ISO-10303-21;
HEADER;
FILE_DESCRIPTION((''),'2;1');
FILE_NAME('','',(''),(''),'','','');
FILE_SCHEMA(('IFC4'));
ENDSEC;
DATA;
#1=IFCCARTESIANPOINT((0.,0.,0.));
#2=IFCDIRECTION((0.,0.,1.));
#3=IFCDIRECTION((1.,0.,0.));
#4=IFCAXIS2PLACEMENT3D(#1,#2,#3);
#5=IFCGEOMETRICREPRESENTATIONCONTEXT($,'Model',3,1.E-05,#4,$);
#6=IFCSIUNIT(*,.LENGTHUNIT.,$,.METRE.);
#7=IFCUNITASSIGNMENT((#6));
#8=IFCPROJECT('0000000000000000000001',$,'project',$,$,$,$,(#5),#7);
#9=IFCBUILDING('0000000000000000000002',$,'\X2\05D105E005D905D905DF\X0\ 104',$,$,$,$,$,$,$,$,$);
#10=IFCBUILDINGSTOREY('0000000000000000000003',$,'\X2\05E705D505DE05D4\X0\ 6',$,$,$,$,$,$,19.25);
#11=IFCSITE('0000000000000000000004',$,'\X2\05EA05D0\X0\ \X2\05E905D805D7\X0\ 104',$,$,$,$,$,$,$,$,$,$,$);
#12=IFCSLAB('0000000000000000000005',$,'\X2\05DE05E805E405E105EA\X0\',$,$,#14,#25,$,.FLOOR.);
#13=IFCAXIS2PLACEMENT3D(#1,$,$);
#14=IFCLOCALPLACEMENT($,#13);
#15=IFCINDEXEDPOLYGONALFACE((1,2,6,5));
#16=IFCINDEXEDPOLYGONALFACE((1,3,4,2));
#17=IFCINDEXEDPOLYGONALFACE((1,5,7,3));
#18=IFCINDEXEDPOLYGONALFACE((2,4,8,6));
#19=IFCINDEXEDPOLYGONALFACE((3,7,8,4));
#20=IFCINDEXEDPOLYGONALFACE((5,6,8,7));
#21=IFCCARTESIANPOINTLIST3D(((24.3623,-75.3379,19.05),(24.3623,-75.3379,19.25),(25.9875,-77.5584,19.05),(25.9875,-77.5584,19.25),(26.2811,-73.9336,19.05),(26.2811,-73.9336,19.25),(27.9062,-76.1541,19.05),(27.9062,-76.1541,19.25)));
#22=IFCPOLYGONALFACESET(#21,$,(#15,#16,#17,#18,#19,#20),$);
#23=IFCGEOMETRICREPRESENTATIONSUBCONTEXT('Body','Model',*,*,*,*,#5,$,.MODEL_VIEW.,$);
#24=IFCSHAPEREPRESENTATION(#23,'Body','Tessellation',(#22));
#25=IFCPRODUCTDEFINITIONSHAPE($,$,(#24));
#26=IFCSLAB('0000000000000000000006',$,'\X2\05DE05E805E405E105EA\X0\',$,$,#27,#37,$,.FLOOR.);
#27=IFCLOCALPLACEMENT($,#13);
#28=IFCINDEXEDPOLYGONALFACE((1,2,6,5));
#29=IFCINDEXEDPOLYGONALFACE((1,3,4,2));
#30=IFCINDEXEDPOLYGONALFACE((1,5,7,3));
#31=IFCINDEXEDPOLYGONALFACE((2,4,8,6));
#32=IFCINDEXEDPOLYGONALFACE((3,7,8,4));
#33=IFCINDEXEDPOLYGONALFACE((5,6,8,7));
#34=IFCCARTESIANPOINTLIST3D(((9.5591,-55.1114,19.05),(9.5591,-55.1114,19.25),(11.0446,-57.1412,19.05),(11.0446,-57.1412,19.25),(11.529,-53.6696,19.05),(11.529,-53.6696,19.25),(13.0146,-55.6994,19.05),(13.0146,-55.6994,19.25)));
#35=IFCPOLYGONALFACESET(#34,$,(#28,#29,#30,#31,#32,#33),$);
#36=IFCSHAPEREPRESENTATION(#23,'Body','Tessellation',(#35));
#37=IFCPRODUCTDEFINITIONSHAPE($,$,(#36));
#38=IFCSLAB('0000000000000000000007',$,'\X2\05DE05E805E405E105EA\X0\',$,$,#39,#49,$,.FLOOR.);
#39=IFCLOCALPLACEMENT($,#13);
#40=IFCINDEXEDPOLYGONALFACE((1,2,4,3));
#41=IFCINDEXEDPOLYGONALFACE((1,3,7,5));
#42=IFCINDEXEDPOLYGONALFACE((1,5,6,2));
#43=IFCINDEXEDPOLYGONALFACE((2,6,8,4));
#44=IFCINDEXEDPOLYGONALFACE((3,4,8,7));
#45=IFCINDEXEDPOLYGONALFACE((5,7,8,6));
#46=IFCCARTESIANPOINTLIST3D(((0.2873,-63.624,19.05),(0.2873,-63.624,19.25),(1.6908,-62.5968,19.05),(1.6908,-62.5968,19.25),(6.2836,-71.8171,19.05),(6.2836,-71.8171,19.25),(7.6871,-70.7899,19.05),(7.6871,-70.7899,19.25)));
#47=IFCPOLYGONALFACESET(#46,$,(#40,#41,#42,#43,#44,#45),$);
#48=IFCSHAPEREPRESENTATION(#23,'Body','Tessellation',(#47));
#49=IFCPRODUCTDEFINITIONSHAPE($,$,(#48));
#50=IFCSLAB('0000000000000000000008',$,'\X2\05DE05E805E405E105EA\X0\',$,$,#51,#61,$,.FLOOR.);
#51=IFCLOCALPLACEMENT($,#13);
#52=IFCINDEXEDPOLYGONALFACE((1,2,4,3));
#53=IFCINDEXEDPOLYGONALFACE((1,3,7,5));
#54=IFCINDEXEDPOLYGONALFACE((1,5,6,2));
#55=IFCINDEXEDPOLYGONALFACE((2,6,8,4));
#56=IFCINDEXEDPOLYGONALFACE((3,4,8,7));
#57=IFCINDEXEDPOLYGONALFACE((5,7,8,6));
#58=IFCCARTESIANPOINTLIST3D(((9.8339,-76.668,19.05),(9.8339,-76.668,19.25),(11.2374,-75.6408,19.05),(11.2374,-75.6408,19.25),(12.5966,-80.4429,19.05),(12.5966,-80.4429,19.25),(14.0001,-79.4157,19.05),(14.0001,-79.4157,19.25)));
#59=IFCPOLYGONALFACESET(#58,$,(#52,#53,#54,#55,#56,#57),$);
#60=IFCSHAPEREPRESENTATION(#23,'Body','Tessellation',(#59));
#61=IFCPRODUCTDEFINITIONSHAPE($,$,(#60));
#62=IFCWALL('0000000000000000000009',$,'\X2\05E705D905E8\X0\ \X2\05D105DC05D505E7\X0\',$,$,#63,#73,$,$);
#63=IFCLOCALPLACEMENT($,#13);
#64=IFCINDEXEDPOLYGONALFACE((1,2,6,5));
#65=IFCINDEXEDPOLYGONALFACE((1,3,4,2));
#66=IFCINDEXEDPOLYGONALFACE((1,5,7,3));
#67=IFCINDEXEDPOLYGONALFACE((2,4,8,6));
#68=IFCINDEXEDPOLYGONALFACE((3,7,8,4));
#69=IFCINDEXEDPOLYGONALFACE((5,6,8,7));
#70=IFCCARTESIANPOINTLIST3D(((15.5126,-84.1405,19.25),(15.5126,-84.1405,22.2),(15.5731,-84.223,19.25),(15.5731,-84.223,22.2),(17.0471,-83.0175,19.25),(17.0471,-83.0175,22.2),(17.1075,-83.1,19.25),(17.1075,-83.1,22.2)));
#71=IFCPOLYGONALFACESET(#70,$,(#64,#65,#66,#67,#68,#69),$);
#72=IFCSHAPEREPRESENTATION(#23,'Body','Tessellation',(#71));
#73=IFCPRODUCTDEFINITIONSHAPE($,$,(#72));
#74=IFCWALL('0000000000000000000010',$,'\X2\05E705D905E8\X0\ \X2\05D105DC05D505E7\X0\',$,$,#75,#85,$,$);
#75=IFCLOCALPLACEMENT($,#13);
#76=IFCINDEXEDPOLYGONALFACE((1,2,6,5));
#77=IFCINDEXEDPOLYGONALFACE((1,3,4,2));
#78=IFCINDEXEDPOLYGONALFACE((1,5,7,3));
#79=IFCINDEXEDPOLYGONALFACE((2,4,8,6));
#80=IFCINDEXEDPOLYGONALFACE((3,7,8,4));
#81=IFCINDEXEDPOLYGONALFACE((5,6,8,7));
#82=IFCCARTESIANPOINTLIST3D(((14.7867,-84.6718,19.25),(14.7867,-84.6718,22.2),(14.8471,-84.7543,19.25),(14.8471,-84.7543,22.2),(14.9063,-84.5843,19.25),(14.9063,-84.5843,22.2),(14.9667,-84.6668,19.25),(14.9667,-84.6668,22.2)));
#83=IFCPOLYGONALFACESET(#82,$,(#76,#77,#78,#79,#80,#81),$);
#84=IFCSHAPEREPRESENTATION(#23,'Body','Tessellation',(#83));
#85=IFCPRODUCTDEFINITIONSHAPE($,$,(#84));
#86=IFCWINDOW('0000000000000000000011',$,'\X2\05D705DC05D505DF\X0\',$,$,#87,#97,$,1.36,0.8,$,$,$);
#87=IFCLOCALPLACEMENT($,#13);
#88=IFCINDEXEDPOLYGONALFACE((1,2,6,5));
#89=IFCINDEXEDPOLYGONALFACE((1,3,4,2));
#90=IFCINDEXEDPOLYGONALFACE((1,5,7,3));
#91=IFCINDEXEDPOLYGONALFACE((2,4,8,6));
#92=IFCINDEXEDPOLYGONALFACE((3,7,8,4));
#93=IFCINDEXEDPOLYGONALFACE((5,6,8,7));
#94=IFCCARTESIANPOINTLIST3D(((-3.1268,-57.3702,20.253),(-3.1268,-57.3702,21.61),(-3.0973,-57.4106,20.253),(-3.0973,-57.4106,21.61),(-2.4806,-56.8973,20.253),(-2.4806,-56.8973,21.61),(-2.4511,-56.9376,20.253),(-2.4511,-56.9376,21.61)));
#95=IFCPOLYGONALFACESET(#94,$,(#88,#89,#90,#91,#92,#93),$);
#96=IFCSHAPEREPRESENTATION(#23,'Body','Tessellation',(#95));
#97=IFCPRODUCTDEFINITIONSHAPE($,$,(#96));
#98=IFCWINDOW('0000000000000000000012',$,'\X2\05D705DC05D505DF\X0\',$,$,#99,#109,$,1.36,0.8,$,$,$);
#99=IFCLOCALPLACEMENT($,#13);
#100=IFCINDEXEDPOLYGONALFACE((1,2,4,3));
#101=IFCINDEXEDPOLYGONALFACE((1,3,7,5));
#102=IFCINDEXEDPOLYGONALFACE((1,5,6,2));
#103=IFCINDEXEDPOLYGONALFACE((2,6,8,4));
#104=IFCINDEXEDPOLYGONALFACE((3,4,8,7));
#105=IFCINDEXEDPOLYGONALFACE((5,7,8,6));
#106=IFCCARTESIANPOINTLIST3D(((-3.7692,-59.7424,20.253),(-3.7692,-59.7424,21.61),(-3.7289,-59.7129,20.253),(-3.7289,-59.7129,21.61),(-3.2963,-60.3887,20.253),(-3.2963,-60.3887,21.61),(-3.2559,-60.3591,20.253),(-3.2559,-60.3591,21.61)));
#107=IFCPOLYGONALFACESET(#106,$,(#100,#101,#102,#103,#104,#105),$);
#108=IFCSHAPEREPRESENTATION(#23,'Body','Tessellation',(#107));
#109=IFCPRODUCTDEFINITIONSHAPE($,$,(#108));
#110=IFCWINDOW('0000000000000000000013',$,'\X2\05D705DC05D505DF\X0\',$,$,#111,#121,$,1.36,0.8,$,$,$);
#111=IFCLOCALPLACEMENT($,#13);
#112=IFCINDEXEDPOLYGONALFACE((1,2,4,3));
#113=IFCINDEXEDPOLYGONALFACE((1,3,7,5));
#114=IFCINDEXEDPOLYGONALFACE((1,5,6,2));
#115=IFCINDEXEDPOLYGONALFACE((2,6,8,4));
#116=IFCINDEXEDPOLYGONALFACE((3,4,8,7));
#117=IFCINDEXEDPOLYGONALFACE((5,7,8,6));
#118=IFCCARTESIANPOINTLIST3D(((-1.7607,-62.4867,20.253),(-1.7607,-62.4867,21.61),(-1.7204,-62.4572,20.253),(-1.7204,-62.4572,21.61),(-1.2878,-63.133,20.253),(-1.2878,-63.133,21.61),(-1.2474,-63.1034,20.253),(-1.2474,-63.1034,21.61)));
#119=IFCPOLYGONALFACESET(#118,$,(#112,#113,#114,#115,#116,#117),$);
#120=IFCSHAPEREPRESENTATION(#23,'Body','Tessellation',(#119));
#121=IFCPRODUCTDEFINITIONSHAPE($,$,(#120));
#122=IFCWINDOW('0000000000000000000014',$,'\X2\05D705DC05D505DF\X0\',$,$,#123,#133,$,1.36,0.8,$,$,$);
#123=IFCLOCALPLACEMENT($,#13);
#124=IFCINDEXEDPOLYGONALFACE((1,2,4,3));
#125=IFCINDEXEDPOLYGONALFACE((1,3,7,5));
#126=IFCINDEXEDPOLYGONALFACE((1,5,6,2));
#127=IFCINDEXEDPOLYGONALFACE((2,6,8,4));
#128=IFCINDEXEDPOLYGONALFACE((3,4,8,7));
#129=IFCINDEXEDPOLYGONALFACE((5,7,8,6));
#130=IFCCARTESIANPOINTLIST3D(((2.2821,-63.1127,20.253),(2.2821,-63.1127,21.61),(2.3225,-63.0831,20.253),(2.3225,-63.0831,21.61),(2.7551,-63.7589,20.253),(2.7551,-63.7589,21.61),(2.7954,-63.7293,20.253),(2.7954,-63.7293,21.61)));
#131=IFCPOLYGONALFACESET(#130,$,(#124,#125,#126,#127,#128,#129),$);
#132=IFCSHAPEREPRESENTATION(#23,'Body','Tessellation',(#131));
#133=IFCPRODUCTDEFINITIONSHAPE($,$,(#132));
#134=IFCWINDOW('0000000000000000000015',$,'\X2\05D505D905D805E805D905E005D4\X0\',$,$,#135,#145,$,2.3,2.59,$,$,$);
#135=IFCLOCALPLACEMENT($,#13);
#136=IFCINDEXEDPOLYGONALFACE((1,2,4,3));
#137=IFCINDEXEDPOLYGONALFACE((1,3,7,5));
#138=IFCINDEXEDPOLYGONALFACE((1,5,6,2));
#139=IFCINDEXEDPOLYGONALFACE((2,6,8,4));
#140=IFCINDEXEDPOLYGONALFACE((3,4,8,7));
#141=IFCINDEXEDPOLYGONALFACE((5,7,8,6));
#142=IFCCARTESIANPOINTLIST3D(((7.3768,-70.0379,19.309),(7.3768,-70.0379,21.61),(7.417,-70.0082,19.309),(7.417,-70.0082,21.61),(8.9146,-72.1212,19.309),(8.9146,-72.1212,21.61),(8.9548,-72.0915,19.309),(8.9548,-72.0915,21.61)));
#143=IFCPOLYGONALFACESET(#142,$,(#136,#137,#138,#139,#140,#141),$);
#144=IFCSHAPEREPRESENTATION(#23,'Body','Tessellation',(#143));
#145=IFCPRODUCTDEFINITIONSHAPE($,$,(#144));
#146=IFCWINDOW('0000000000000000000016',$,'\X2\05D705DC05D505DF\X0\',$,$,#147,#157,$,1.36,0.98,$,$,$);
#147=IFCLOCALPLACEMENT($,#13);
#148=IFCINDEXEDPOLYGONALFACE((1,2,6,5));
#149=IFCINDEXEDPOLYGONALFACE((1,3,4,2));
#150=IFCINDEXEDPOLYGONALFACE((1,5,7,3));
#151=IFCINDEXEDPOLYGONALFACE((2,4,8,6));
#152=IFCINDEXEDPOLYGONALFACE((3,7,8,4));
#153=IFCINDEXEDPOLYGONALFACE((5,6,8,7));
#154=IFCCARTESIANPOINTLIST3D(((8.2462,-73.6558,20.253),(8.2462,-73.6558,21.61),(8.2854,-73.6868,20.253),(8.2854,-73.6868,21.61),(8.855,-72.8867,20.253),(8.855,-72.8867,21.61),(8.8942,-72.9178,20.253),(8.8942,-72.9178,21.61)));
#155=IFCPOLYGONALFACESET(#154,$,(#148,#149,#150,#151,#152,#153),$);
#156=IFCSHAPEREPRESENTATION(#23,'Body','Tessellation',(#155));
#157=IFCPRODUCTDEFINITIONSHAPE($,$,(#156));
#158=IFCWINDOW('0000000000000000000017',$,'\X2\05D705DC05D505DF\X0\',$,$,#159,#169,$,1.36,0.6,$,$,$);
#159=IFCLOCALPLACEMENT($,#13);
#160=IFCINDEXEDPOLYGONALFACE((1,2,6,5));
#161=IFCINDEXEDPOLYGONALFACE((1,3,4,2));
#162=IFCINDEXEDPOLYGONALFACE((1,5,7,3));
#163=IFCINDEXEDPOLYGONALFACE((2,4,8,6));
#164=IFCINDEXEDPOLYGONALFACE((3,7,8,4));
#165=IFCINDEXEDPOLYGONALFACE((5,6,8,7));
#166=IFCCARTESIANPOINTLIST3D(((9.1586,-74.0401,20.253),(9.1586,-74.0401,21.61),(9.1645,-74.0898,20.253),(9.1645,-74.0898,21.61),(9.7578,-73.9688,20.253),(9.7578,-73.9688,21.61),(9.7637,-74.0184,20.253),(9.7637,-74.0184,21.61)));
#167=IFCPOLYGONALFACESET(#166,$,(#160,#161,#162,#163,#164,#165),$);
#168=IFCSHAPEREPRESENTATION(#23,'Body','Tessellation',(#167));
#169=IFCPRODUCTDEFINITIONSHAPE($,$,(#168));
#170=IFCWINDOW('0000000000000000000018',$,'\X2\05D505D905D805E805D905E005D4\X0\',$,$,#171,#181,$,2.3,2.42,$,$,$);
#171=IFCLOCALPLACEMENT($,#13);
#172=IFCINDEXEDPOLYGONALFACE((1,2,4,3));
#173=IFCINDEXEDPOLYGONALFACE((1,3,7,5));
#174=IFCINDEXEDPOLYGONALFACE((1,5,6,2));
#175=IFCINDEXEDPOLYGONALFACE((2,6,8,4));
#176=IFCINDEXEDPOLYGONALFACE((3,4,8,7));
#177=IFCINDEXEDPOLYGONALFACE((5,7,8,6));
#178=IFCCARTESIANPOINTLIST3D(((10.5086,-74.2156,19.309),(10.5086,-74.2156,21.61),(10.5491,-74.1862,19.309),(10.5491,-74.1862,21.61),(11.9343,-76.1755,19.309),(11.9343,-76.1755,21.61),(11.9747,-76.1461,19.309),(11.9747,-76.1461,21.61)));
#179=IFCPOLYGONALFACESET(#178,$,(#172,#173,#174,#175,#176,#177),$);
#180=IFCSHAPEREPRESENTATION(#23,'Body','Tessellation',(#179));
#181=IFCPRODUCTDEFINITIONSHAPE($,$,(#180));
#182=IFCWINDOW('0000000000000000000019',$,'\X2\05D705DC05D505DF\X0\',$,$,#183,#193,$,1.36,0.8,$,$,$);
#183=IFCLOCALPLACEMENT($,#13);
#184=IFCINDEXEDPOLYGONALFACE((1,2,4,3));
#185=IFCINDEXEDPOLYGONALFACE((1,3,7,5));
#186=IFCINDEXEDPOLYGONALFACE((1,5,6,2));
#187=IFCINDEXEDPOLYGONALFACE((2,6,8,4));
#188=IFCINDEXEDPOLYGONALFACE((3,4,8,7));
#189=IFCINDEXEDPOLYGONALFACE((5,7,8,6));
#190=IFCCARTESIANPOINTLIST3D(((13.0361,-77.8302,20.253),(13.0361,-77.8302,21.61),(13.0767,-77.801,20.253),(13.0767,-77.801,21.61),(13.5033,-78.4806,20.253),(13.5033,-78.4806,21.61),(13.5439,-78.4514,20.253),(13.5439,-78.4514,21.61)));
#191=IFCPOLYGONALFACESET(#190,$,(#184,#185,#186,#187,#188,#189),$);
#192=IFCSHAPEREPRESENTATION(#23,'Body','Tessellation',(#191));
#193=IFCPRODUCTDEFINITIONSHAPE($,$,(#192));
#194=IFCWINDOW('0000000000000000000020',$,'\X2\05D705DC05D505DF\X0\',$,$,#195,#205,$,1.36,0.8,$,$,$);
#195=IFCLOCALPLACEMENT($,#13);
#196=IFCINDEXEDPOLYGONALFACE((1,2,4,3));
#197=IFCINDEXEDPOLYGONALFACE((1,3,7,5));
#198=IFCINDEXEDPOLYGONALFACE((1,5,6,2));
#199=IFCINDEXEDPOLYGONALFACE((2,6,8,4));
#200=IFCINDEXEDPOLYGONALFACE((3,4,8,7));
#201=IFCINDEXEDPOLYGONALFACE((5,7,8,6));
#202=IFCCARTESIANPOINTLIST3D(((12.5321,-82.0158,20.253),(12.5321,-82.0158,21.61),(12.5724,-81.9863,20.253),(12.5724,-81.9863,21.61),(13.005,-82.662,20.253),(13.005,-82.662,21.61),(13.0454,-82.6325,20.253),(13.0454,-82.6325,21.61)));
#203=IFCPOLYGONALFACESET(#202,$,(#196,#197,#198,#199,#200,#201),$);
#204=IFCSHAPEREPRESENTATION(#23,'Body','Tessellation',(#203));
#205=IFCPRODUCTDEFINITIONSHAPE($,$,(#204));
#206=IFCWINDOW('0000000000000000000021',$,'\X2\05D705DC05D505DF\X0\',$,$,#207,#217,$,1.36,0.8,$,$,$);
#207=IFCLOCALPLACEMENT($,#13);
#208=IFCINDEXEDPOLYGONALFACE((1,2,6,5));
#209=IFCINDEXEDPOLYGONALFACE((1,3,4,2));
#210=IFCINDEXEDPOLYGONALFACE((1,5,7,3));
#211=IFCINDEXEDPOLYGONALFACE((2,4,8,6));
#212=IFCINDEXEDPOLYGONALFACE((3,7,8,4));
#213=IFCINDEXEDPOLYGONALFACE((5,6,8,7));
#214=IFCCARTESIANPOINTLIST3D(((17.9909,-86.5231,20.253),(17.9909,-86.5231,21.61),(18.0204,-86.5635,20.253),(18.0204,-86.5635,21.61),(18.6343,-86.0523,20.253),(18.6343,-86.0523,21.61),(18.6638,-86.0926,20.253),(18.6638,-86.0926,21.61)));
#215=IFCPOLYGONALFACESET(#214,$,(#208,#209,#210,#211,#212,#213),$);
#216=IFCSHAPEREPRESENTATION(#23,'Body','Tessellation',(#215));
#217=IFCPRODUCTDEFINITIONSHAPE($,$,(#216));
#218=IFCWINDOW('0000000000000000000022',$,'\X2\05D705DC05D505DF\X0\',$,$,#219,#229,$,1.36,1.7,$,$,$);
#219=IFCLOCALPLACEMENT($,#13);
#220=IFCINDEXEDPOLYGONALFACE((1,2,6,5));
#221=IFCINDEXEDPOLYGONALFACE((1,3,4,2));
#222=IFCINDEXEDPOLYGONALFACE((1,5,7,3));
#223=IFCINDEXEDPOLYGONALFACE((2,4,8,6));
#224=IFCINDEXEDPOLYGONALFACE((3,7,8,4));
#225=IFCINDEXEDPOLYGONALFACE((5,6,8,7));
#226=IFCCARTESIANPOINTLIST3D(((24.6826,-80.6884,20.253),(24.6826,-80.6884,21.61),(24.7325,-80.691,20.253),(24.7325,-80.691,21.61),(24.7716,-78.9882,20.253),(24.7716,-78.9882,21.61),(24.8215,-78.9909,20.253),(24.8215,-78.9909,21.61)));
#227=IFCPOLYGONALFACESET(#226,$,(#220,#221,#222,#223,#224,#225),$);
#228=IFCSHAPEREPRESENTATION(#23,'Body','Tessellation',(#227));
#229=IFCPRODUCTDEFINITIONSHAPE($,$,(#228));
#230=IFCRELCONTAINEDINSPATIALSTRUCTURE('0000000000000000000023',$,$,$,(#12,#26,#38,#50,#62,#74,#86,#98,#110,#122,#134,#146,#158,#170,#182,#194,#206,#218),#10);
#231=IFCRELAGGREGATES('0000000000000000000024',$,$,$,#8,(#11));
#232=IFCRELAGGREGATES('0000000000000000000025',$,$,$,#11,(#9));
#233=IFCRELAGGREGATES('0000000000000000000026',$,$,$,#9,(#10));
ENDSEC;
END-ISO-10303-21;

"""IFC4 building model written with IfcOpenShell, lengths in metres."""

from ifc_helpers import new_model, si_unit, frame, origin_with_axes, context, subcontext, project, spatial, polyline, outline, extrude, element, save


model = new_model("IFC4")

# Units and contexts
model_context = context("Model", 3, precision=1e-05, world=origin_with_axes())
body_context = subcontext(model_context, "Body", "Model", "MODEL_VIEW")
ifc_project = project(units=[si_unit("LENGTHUNIT", "METRE")], contexts=[model_context])

# Site, building, storey
site = spatial("IfcSite", under=ifc_project, Name="תא שטח 104")
building = spatial("IfcBuilding", under=site, Name="בניין 104")
storey = spatial("IfcBuildingStorey", under=building, Name="קומה 6", Elevation=19.25)

# Slabs
element("IfcSlab", 1, inside=storey, Name="מרפסת", PredefinedType="FLOOR", context=body_context, shape_type="SweptSolid", body=[
    extrude(outline(polyline([(26.2811, -73.9336), (27.9062, -76.1541), (25.9875, -77.5584), (24.3623, -75.3379), (26.2811, -73.9336)])), frame((0.0, 0.0, 19.05)), (0.0, 0.0, 1.0), 0.2),
])
element("IfcSlab", 2, inside=storey, Name="מרפסת", PredefinedType="FLOOR", context=body_context, shape_type="SweptSolid", body=[
    extrude(outline(polyline([(11.529, -53.6696), (13.0146, -55.6994), (11.0446, -57.1412), (9.5591, -55.1114), (11.529, -53.6696)])), frame((0.0, 0.0, 19.05)), (0.0, 0.0, 1.0), 0.2),
])
element("IfcSlab", 3, inside=storey, Name="מרפסת", PredefinedType="FLOOR", context=body_context, shape_type="SweptSolid", body=[
    extrude(outline(polyline([(1.6908, -62.5968), (7.6871, -70.7899), (6.2836, -71.8171), (0.2873, -63.624), (1.6908, -62.5968)])), frame((0.0, 0.0, 19.05)), (0.0, 0.0, 1.0), 0.2),
])
element("IfcSlab", 4, inside=storey, Name="מרפסת", PredefinedType="FLOOR", context=body_context, shape_type="SweptSolid", body=[
    extrude(outline(polyline([(11.2374, -75.6408), (14.0001, -79.4157), (12.5966, -80.4429), (9.8339, -76.668), (11.2374, -75.6408)])), frame((0.0, 0.0, 19.05)), (0.0, 0.0, 1.0), 0.2),
])

# Walls
element("IfcWall", 5, inside=storey, Name="קיר בלוק", context=body_context, shape_type="SweptSolid", body=[
    extrude(outline(polyline([(17.1075, -83.1), (17.0471, -83.0175), (15.5126, -84.1405), (15.5731, -84.223), (17.1075, -83.1)])), frame((0.0, 0.0, 19.25)), (0.0, 0.0, 1.0), 2.95),
])
element("IfcWall", 6, inside=storey, Name="קיר בלוק", context=body_context, shape_type="SweptSolid", body=[
    extrude(outline(polyline([(14.7867, -84.6718), (14.8471, -84.7543), (14.9667, -84.6668), (14.9063, -84.5843), (14.7867, -84.6718)])), frame((0.0, 0.0, 19.25)), (0.0, 0.0, 1.0), 2.95),
])

# Windows
element("IfcWindow", 7, inside=storey, Name="חלון", OverallHeight=1.36, OverallWidth=0.8, context=body_context, shape_type="SweptSolid", body=[
    extrude(outline(polyline([(-2.4806, -56.8973), (-3.1268, -57.3702), (-3.0973, -57.4106), (-2.4511, -56.9376), (-2.4806, -56.8973)])), frame((0.0, 0.0, 20.253)), (0.0, 0.0, 1.0), 1.357),
])
element("IfcWindow", 8, inside=storey, Name="חלון", OverallHeight=1.36, OverallWidth=0.8, context=body_context, shape_type="SweptSolid", body=[
    extrude(outline(polyline([(-3.7692, -59.7424), (-3.2963, -60.3887), (-3.2559, -60.3591), (-3.7289, -59.7129), (-3.7692, -59.7424)])), frame((0.0, 0.0, 20.253)), (0.0, 0.0, 1.0), 1.357),
])
element("IfcWindow", 9, inside=storey, Name="חלון", OverallHeight=1.36, OverallWidth=0.8, context=body_context, shape_type="SweptSolid", body=[
    extrude(outline(polyline([(-1.7607, -62.4867), (-1.2878, -63.133), (-1.2474, -63.1034), (-1.7204, -62.4572), (-1.7607, -62.4867)])), frame((0.0, 0.0, 20.253)), (0.0, 0.0, 1.0), 1.357),
])
element("IfcWindow", 10, inside=storey, Name="חלון", OverallHeight=1.36, OverallWidth=0.8, context=body_context, shape_type="SweptSolid", body=[
    extrude(outline(polyline([(2.2821, -63.1127), (2.7551, -63.7589), (2.7954, -63.7293), (2.3225, -63.0831), (2.2821, -63.1127)])), frame((0.0, 0.0, 20.253)), (0.0, 0.0, 1.0), 1.357),
])
element("IfcWindow", 11, inside=storey, Name="ויטרינה", OverallHeight=2.3, OverallWidth=2.59, context=body_context, shape_type="SweptSolid", body=[
    extrude(outline(polyline([(7.3768, -70.0379), (8.9146, -72.1212), (8.9548, -72.0915), (7.417, -70.0082), (7.3768, -70.0379)])), frame((0.0, 0.0, 19.309)), (0.0, 0.0, 1.0), 2.301),
])
element("IfcWindow", 12, inside=storey, Name="חלון", OverallHeight=1.36, OverallWidth=0.98, context=body_context, shape_type="SweptSolid", body=[
    extrude(outline(polyline([(8.855, -72.8867), (8.2462, -73.6558), (8.2854, -73.6868), (8.8942, -72.9178), (8.855, -72.8867)])), frame((0.0, 0.0, 20.253)), (0.0, 0.0, 1.0), 1.357),
])
element("IfcWindow", 13, inside=storey, Name="חלון", OverallHeight=1.36, OverallWidth=0.6, context=body_context, shape_type="SweptSolid", body=[
    extrude(outline(polyline([(9.1645, -74.0898), (9.7637, -74.0184), (9.7578, -73.9688), (9.1586, -74.0401), (9.1645, -74.0898)])), frame((0.0, 0.0, 20.253)), (0.0, 0.0, 1.0), 1.357),
])
element("IfcWindow", 14, inside=storey, Name="ויטרינה", OverallHeight=2.3, OverallWidth=2.42, context=body_context, shape_type="SweptSolid", body=[
    extrude(outline(polyline([(10.5086, -74.2156), (11.9343, -76.1755), (11.9747, -76.1461), (10.5491, -74.1862), (10.5086, -74.2156)])), frame((0.0, 0.0, 19.309)), (0.0, 0.0, 1.0), 2.301),
])
element("IfcWindow", 15, inside=storey, Name="חלון", OverallHeight=1.36, OverallWidth=0.8, context=body_context, shape_type="SweptSolid", body=[
    extrude(outline(polyline([(13.0361, -77.8302), (13.5033, -78.4806), (13.5439, -78.4514), (13.0767, -77.801), (13.0361, -77.8302)])), frame((0.0, 0.0, 20.253)), (0.0, 0.0, 1.0), 1.357),
])
element("IfcWindow", 16, inside=storey, Name="חלון", OverallHeight=1.36, OverallWidth=0.8, context=body_context, shape_type="SweptSolid", body=[
    extrude(outline(polyline([(12.5321, -82.0158), (13.005, -82.662), (13.0454, -82.6325), (12.5724, -81.9863), (12.5321, -82.0158)])), frame((0.0, 0.0, 20.253)), (0.0, 0.0, 1.0), 1.357),
])
element("IfcWindow", 17, inside=storey, Name="חלון", OverallHeight=1.36, OverallWidth=0.8, context=body_context, shape_type="SweptSolid", body=[
    extrude(outline(polyline([(18.0204, -86.5635), (18.6638, -86.0926), (18.6343, -86.0523), (17.9909, -86.5231), (18.0204, -86.5635)])), frame((0.0, 0.0, 20.253)), (0.0, 0.0, 1.0), 1.357),
])
element("IfcWindow", 18, inside=storey, Name="חלון", OverallHeight=1.36, OverallWidth=1.7, context=body_context, shape_type="SweptSolid", body=[
    extrude(outline(polyline([(24.7325, -80.691), (24.8215, -78.9909), (24.7716, -78.9882), (24.6826, -80.6884), (24.7325, -80.691)])), frame((0.0, 0.0, 20.253)), (0.0, 0.0, 1.0), 1.357),
])

save(model, "model.ifc")
